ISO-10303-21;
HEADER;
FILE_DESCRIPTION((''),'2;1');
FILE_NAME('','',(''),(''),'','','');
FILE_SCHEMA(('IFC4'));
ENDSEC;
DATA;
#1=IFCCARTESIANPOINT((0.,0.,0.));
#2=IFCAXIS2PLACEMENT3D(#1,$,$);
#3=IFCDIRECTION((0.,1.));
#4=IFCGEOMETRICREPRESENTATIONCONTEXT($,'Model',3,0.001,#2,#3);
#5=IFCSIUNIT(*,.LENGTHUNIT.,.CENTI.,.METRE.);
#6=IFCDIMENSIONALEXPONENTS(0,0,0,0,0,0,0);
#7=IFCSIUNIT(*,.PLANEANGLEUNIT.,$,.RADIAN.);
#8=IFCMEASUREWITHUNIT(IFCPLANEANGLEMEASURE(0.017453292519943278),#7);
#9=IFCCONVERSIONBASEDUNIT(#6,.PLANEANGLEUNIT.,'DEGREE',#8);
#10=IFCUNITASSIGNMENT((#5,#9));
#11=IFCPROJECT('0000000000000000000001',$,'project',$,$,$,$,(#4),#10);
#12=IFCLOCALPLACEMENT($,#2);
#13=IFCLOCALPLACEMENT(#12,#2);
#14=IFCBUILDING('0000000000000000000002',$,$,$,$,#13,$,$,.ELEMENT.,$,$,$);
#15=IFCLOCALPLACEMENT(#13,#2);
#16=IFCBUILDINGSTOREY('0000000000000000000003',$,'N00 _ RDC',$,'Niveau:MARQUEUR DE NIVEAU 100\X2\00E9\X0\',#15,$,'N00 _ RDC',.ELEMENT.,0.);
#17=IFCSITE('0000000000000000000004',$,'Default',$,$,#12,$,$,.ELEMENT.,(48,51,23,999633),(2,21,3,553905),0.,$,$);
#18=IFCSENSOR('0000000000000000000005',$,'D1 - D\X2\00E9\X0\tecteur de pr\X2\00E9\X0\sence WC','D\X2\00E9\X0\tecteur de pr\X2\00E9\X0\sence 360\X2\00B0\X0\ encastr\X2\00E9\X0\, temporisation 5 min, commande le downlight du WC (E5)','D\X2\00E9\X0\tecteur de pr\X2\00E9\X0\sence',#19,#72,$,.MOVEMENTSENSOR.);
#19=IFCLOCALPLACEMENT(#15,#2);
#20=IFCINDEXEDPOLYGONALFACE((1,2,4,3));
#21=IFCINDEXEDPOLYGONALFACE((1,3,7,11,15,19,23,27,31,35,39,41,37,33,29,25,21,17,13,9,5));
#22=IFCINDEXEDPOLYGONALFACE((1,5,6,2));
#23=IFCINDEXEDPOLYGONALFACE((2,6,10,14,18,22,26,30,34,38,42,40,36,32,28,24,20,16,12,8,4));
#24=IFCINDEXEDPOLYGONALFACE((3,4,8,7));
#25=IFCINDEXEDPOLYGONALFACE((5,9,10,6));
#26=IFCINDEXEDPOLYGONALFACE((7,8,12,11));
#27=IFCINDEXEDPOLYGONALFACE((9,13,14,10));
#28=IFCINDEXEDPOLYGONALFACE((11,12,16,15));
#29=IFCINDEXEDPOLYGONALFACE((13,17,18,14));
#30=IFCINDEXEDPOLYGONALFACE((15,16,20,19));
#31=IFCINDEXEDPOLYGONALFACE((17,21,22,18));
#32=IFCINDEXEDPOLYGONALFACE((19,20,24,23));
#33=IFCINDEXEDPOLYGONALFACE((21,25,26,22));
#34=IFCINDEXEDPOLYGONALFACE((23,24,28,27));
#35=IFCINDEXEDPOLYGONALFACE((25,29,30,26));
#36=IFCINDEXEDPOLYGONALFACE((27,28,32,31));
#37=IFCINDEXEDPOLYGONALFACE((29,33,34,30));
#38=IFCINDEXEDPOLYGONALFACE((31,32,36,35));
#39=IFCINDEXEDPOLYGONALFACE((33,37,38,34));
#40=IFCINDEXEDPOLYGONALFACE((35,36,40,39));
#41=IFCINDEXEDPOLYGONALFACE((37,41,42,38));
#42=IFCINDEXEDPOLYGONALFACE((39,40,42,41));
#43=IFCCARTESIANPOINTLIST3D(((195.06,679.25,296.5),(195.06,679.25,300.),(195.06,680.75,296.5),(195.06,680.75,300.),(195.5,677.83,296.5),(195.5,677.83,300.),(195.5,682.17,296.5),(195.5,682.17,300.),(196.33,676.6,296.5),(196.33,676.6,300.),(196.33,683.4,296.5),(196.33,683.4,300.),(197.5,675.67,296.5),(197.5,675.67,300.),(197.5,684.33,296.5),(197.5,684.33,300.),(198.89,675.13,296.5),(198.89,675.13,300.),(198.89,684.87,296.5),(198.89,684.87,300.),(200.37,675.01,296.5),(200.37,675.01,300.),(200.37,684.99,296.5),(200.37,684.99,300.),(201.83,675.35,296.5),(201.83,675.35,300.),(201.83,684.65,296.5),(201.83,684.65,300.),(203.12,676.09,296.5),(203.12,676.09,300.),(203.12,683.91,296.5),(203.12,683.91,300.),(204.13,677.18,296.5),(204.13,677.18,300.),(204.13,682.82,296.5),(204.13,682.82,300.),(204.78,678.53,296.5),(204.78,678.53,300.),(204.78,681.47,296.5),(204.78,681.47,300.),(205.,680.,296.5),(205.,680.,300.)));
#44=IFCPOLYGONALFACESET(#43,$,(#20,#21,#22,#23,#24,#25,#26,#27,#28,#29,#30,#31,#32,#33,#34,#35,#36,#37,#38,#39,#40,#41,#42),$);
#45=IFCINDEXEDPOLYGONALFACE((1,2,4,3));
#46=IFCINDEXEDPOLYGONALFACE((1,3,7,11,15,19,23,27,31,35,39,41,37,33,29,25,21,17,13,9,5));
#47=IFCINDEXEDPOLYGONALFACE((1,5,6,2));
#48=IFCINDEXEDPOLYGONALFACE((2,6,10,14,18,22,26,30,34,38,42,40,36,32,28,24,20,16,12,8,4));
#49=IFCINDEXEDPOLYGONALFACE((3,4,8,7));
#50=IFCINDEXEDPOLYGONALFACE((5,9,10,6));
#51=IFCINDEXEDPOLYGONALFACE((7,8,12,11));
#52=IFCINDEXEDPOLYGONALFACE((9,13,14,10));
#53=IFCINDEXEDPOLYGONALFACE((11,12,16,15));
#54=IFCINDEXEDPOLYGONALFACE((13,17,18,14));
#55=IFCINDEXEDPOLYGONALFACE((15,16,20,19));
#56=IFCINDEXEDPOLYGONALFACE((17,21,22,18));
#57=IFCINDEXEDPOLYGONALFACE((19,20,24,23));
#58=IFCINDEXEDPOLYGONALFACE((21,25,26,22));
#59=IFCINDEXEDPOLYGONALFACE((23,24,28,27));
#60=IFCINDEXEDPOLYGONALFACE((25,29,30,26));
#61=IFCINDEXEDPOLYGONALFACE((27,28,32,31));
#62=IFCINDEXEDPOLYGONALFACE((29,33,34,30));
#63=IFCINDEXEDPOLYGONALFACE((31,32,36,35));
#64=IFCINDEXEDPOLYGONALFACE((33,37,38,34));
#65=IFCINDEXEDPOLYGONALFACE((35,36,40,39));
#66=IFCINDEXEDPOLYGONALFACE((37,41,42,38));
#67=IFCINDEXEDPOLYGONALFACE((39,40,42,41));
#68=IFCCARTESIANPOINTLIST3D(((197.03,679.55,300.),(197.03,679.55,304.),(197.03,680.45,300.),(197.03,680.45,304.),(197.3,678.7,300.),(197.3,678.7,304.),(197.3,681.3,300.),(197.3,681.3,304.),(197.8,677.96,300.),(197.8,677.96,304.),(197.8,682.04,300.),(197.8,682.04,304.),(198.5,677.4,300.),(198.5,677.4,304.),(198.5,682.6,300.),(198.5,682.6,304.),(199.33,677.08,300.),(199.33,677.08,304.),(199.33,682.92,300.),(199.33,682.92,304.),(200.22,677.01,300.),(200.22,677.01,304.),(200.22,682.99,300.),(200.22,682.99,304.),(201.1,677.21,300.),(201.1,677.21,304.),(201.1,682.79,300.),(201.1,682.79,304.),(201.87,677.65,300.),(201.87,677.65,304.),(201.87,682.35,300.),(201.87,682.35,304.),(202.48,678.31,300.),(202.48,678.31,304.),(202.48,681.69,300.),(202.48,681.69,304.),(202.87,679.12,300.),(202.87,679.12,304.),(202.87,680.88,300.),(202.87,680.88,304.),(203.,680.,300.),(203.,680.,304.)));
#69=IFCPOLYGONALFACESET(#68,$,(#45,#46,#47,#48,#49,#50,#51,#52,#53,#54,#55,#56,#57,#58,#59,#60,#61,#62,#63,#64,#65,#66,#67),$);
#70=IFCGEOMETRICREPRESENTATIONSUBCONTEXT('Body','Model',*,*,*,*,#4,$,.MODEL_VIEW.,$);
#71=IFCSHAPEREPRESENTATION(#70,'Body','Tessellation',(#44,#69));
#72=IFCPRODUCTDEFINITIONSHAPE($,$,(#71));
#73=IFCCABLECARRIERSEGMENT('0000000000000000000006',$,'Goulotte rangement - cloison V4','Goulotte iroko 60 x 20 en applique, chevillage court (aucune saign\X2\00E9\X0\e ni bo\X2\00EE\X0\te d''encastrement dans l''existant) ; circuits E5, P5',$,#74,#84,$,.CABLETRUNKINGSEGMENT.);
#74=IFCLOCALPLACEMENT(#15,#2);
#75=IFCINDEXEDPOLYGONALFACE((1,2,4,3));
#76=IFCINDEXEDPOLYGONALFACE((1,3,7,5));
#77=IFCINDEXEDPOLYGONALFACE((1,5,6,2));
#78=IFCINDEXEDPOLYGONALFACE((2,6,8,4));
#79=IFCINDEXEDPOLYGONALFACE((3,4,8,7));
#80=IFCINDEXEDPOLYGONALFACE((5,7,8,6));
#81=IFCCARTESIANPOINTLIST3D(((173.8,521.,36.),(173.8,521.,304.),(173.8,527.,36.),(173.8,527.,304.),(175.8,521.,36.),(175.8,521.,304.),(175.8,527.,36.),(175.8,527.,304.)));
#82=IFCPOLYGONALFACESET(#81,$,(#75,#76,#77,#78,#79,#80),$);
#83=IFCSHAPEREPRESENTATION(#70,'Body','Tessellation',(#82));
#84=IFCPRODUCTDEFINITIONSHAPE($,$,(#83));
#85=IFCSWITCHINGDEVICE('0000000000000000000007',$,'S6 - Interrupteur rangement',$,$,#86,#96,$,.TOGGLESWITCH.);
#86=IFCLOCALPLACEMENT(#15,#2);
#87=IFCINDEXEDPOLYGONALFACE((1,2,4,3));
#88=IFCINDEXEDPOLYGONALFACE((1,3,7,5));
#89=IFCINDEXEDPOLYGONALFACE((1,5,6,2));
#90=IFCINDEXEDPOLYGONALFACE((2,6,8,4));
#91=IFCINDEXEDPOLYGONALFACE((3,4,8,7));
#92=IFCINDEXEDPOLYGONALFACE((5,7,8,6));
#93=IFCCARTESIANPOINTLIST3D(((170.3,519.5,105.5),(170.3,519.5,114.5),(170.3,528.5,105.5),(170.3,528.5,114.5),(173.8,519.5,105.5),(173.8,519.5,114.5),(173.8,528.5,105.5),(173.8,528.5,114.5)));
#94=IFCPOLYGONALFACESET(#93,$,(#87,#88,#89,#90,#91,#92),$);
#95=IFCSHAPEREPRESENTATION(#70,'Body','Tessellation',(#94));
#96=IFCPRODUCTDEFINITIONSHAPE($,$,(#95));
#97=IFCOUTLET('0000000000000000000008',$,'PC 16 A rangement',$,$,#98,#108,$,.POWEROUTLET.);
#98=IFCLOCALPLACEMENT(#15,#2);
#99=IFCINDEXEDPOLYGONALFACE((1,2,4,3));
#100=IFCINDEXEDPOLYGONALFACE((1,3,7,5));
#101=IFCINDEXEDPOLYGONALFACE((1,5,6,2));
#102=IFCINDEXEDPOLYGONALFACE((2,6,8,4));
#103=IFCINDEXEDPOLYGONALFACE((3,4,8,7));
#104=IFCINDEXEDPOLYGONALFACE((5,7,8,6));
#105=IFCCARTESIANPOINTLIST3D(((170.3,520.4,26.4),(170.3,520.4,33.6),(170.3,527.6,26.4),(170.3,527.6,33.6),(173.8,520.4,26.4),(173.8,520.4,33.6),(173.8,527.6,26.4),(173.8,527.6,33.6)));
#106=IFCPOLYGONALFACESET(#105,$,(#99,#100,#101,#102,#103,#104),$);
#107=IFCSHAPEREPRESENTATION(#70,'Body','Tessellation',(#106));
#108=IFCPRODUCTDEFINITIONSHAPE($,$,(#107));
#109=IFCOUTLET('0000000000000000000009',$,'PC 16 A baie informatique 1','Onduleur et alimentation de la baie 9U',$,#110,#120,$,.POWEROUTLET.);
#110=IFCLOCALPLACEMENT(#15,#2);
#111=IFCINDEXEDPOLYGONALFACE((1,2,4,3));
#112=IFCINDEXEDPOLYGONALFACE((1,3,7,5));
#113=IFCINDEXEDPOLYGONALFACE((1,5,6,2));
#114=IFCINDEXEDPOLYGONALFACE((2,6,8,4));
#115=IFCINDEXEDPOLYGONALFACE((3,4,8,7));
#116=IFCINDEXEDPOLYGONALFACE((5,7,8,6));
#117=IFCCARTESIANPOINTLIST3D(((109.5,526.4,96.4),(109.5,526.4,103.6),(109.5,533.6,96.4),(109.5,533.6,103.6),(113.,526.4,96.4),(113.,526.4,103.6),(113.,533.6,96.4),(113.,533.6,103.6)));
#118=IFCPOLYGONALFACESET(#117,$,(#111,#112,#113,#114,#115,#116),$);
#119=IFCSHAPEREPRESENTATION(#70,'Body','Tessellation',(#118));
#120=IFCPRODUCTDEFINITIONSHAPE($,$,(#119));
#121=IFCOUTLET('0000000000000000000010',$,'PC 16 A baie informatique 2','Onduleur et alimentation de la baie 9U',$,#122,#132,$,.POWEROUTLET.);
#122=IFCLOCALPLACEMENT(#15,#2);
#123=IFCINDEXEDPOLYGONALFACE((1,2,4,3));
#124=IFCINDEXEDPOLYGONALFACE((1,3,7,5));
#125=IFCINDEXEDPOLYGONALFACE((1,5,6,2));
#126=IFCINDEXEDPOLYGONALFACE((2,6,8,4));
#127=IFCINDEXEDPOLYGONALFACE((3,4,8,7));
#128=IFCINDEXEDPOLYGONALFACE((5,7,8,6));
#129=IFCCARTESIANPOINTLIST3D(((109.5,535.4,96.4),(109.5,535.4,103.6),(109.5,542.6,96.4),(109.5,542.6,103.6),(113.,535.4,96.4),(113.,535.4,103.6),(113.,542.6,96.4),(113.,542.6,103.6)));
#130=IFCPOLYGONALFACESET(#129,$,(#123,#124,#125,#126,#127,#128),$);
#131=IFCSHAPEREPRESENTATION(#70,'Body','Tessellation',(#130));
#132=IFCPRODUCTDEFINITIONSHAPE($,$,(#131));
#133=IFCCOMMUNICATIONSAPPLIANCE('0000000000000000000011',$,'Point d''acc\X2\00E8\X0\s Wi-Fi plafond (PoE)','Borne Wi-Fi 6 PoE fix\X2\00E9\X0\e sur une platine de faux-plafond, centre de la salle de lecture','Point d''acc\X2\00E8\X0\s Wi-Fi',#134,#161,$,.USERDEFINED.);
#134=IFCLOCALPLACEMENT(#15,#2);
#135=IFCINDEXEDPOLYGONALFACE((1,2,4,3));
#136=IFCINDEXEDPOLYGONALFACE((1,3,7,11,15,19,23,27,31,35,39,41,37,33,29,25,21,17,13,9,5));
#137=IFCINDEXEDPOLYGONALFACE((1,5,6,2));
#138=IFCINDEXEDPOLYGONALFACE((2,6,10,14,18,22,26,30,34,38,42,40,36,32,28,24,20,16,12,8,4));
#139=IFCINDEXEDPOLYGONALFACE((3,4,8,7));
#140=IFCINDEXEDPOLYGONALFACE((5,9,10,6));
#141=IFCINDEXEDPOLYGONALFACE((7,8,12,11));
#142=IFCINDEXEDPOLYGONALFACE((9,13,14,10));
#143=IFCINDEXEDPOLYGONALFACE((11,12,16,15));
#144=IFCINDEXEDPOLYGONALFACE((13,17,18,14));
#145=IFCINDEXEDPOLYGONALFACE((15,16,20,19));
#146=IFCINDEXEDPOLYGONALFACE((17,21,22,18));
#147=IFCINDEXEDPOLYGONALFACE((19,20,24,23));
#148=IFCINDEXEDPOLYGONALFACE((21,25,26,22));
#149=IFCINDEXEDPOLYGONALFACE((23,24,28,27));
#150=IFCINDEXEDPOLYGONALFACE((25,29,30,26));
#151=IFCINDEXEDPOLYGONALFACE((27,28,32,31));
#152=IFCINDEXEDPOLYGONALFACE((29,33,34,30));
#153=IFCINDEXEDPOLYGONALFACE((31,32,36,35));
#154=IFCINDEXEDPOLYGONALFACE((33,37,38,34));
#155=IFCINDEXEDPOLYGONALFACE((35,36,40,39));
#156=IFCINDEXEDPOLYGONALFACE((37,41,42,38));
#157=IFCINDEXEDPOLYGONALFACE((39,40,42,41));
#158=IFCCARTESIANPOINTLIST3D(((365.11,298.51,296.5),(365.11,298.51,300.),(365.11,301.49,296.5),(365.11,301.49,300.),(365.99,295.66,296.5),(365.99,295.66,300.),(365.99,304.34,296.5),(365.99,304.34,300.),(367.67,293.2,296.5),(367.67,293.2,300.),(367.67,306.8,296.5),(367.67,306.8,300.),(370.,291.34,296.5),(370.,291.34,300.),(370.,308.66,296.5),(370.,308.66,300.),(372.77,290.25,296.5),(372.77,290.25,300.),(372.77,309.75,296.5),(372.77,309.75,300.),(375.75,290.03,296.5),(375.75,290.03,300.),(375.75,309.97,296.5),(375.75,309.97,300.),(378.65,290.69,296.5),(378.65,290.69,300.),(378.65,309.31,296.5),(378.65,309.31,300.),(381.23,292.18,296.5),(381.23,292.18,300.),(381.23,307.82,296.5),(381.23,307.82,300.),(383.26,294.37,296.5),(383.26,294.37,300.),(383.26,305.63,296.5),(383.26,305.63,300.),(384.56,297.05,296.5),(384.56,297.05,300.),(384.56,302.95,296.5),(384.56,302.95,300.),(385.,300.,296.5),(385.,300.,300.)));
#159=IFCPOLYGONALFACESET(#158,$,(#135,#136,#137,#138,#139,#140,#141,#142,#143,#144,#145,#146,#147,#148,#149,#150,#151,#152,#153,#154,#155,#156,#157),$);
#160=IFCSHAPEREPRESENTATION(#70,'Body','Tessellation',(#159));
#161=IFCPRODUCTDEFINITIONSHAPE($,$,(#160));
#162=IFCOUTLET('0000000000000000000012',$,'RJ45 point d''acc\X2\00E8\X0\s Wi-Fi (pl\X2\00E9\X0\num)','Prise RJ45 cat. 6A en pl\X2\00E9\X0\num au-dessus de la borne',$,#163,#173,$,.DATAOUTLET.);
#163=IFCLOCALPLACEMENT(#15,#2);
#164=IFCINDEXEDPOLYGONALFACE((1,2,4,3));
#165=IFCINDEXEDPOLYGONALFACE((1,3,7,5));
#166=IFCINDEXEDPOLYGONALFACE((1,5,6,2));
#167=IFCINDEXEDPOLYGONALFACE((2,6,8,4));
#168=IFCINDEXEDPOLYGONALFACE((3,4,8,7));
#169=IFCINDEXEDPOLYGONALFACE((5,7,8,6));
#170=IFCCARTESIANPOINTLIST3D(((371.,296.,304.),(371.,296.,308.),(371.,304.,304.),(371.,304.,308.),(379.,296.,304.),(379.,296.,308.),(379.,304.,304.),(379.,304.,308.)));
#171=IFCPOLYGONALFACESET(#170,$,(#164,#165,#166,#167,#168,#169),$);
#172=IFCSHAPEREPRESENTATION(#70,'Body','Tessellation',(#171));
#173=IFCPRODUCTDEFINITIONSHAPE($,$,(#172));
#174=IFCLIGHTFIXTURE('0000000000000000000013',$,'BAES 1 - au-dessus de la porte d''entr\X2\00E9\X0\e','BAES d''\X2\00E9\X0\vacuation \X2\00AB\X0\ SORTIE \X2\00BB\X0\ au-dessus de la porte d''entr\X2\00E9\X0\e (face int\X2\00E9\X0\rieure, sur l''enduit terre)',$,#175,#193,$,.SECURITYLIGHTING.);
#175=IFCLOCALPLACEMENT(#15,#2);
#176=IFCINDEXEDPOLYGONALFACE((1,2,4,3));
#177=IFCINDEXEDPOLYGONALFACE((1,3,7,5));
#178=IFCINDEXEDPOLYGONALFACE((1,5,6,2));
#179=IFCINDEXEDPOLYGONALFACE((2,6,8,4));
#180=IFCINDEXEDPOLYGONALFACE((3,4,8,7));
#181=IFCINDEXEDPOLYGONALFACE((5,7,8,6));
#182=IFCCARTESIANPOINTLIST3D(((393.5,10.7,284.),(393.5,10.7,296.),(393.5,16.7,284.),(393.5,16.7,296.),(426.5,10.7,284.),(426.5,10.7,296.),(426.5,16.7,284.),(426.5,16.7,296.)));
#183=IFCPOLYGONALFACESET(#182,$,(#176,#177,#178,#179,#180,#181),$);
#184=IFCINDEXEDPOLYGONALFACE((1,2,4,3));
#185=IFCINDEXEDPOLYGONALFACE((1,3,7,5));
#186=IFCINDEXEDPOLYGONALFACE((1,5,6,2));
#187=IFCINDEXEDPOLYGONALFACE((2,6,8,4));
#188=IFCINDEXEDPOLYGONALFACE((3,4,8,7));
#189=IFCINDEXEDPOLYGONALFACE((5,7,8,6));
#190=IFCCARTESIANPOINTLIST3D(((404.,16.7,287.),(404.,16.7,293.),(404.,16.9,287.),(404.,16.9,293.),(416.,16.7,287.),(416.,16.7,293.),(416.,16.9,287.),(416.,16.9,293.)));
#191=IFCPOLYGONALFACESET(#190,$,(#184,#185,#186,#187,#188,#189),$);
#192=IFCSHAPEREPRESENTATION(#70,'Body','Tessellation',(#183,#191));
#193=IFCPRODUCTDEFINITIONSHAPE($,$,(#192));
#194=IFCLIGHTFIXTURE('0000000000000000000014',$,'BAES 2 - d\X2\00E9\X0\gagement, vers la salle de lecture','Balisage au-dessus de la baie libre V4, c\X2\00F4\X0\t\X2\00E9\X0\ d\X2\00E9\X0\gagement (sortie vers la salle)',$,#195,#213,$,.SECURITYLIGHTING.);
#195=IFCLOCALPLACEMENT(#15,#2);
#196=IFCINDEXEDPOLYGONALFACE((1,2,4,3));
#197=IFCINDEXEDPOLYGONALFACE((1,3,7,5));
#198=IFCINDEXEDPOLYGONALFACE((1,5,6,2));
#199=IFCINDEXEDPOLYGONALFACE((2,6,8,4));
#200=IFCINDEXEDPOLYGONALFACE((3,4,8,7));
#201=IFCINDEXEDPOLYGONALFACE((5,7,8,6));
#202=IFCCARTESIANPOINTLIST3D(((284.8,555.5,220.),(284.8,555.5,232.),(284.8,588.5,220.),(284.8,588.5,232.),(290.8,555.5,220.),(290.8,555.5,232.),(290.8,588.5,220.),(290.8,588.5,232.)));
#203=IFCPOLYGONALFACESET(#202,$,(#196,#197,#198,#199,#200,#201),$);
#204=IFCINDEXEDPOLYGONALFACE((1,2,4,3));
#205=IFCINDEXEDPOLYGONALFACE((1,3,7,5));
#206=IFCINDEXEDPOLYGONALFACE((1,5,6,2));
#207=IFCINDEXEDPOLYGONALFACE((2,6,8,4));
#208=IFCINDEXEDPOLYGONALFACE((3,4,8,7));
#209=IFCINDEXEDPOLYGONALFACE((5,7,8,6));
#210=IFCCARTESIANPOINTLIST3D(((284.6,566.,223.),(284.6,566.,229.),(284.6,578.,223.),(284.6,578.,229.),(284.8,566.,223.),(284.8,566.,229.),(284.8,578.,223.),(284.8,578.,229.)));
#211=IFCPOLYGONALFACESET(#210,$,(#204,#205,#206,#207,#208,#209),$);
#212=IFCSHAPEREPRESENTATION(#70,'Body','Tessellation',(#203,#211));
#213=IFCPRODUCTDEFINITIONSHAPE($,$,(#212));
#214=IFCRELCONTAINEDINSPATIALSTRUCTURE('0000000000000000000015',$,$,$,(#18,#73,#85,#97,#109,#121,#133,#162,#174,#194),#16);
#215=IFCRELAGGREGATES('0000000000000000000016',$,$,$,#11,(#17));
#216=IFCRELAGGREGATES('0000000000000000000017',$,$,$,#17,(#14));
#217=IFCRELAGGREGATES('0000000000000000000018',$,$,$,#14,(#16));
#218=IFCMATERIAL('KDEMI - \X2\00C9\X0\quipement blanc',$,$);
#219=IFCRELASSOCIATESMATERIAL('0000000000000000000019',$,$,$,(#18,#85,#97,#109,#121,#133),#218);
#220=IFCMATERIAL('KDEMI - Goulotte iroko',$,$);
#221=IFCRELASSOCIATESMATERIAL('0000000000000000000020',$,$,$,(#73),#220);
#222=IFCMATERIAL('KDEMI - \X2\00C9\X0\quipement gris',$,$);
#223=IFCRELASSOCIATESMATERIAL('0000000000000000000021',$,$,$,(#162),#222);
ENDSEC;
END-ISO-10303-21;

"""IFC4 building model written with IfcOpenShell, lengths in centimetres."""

from ifc_helpers import new_model, entity, si_unit, converted_unit, direction, frame, frame_2d, origin, origin_with_axes, place, context, subcontext, project, spatial, rectangle, circle, extrude, material, element, save


model = new_model("IFC4")

# Units and contexts
model_context = context("Model", 3, precision=0.001, world=origin(), true_north=direction((0.0, 1.0)))
body_context = subcontext(model_context, "Body", "Model", "MODEL_VIEW")
ifc_project = project(units=[si_unit("LENGTHUNIT", "METRE", prefix="CENTI"), converted_unit("PLANEANGLEUNIT", "DEGREE", entity("IfcPlaneAngleMeasure", 0.017453292519943278), si_unit("PLANEANGLEUNIT", "RADIAN"), dimensions=[0, 0, 0, 0, 0, 0, 0])], contexts=[model_context])

# Site, building, storey
site_placement = place(None, origin())
site = spatial("IfcSite", under=ifc_project, at=site_placement, Name="Default", CompositionType="ELEMENT", RefLatitude=(48, 51, 23, 999633), RefLongitude=(2, 21, 3, 553905), RefElevation=0.0)
building_placement = place(site_placement, origin())
building = spatial("IfcBuilding", under=site, at=building_placement, CompositionType="ELEMENT")
storey_placement = place(building_placement, origin())
storey = spatial("IfcBuildingStorey", under=building, at=storey_placement, Name="N00 _ RDC", ObjectType="Niveau:MARQUEUR DE NIVEAU 100é", LongName="N00 _ RDC", CompositionType="ELEMENT", Elevation=0.0)

# Sensor
ifc_material_1 = material(Name="KDEMI - Équipement blanc")
sensor_placement = place(storey_placement, origin_with_axes())
element("IfcSensor", 1, at=sensor_placement, inside=storey, material=ifc_material_1, Name="D1 - Détecteur de présence WC", Description="Détecteur de présence 360° encastré, temporisation 5 min, commande le downlight du WC (E5)", ObjectType="Détecteur de présence", PredefinedType="MOVEMENTSENSOR", context=body_context, shape_type="SweptSolid", body=[
    extrude(circle(Radius=5.0, at=frame_2d((200.0, 680.0))), frame((0.0, 0.0, 296.5)), (0.0, 0.0, 1.0), 3.5),
    extrude(circle(Radius=3.0, at=frame_2d((200.0, 680.0))), frame((0.0, 0.0, 300.0)), (0.0, 0.0, 1.0), 4.0),
])

# Cable carrier segment
ifc_material_2 = material(Name="KDEMI - Goulotte iroko")
cable_carrier_segment_placement = place(storey_placement, origin_with_axes())
element("IfcCableCarrierSegment", 2, at=cable_carrier_segment_placement, inside=storey, material=ifc_material_2, Name="Goulotte rangement - cloison V4", Description="Goulotte iroko 60 x 20 en applique, chevillage court (aucune saignée ni boîte d'encastrement dans l'existant) ; circuits E5, P5", PredefinedType="CABLETRUNKINGSEGMENT", context=body_context, shape_type="SweptSolid", body=[
    extrude(rectangle(XDim=2.0, YDim=6.0, at=frame_2d((174.8, 524.0))), frame((0.0, 0.0, 36.0)), (0.0, 0.0, 1.0), 268.0),
])

# Switching device
switching_device_placement = place(storey_placement, origin_with_axes())
element("IfcSwitchingDevice", 3, at=switching_device_placement, inside=storey, material=ifc_material_1, Name="S6 - Interrupteur rangement", PredefinedType="TOGGLESWITCH", context=body_context, shape_type="SweptSolid", body=[
    extrude(rectangle(XDim=3.5, YDim=9.0, at=frame_2d((172.05, 524.0))), frame((0.0, 0.0, 105.5)), (0.0, 0.0, 1.0), 9.0),
])

# Outlets
outlet_1_placement = place(storey_placement, origin_with_axes())
element("IfcOutlet", 4, at=outlet_1_placement, inside=storey, material=ifc_material_1, Name="PC 16 A rangement", PredefinedType="POWEROUTLET", context=body_context, shape_type="SweptSolid", body=[
    extrude(rectangle(XDim=3.5, YDim=7.2, at=frame_2d((172.05, 524.0))), frame((0.0, 0.0, 26.4)), (0.0, 0.0, 1.0), 7.2),
])
outlet_2_placement = place(storey_placement, origin_with_axes())
element("IfcOutlet", 5, at=outlet_2_placement, inside=storey, material=ifc_material_1, Name="PC 16 A baie informatique 1", Description="Onduleur et alimentation de la baie 9U", PredefinedType="POWEROUTLET", context=body_context, shape_type="SweptSolid", body=[
    extrude(rectangle(XDim=3.5, YDim=7.2, at=frame_2d((111.25, 530.0))), frame((0.0, 0.0, 96.4)), (0.0, 0.0, 1.0), 7.2),
])
outlet_3_placement = place(storey_placement, origin_with_axes())
element("IfcOutlet", 6, at=outlet_3_placement, inside=storey, material=ifc_material_1, Name="PC 16 A baie informatique 2", Description="Onduleur et alimentation de la baie 9U", PredefinedType="POWEROUTLET", context=body_context, shape_type="SweptSolid", body=[
    extrude(rectangle(XDim=3.5, YDim=7.2, at=frame_2d((111.25, 539.0))), frame((0.0, 0.0, 96.4)), (0.0, 0.0, 1.0), 7.2),
])

# Communications appliance
communications_appliance_placement = place(storey_placement, origin_with_axes())
element("IfcCommunicationsAppliance", 7, at=communications_appliance_placement, inside=storey, material=ifc_material_1, Name="Point d'accès Wi-Fi plafond (PoE)", Description="Borne Wi-Fi 6 PoE fixée sur une platine de faux-plafond, centre de la salle de lecture", ObjectType="Point d'accès Wi-Fi", PredefinedType="USERDEFINED", context=body_context, shape_type="SweptSolid", body=[
    extrude(circle(Radius=10.0, at=frame_2d((375.0, 300.0))), frame((0.0, 0.0, 296.5)), (0.0, 0.0, 1.0), 3.5),
])

# Outlet
ifc_material_3 = material(Name="KDEMI - Équipement gris")
outlet_4_placement = place(storey_placement, origin_with_axes())
element("IfcOutlet", 8, at=outlet_4_placement, inside=storey, material=ifc_material_3, Name="RJ45 point d'accès Wi-Fi (plénum)", Description="Prise RJ45 cat. 6A en plénum au-dessus de la borne", PredefinedType="DATAOUTLET", context=body_context, shape_type="SweptSolid", body=[
    extrude(rectangle(XDim=8.0, YDim=8.0, at=frame_2d((375.0, 300.0))), frame((0.0, 0.0, 304.0)), (0.0, 0.0, 1.0), 4.0),
])

# Light fixtures
light_fixture_1_placement = place(storey_placement, origin_with_axes())
element("IfcLightFixture", 9, at=light_fixture_1_placement, inside=storey, Name="BAES 1 - au-dessus de la porte d'entrée", Description="BAES d'évacuation « SORTIE » au-dessus de la porte d'entrée (face intérieure, sur l'enduit terre)", PredefinedType="SECURITYLIGHTING", context=body_context, shape_type="SweptSolid", body=[
    extrude(rectangle(XDim=33.0, YDim=6.0, at=frame_2d((410.0, 13.7))), frame((0.0, 0.0, 284.0)), (0.0, 0.0, 1.0), 12.0),
    extrude(rectangle(XDim=12.0, YDim=0.2, at=frame_2d((410.0, 16.8))), frame((0.0, 0.0, 287.0)), (0.0, 0.0, 1.0), 6.0),
])
light_fixture_2_placement = place(storey_placement, origin_with_axes())
element("IfcLightFixture", 10, at=light_fixture_2_placement, inside=storey, Name="BAES 2 - dégagement, vers la salle de lecture", Description="Balisage au-dessus de la baie libre V4, côté dégagement (sortie vers la salle)", PredefinedType="SECURITYLIGHTING", context=body_context, shape_type="SweptSolid", body=[
    extrude(rectangle(XDim=6.0, YDim=33.0, at=frame_2d((287.8, 572.0))), frame((0.0, 0.0, 220.0)), (0.0, 0.0, 1.0), 12.0),
    extrude(rectangle(XDim=0.2, YDim=12.0, at=frame_2d((284.7, 572.0))), frame((0.0, 0.0, 223.0)), (0.0, 0.0, 1.0), 6.0),
])

save(model, "model.ifc")
